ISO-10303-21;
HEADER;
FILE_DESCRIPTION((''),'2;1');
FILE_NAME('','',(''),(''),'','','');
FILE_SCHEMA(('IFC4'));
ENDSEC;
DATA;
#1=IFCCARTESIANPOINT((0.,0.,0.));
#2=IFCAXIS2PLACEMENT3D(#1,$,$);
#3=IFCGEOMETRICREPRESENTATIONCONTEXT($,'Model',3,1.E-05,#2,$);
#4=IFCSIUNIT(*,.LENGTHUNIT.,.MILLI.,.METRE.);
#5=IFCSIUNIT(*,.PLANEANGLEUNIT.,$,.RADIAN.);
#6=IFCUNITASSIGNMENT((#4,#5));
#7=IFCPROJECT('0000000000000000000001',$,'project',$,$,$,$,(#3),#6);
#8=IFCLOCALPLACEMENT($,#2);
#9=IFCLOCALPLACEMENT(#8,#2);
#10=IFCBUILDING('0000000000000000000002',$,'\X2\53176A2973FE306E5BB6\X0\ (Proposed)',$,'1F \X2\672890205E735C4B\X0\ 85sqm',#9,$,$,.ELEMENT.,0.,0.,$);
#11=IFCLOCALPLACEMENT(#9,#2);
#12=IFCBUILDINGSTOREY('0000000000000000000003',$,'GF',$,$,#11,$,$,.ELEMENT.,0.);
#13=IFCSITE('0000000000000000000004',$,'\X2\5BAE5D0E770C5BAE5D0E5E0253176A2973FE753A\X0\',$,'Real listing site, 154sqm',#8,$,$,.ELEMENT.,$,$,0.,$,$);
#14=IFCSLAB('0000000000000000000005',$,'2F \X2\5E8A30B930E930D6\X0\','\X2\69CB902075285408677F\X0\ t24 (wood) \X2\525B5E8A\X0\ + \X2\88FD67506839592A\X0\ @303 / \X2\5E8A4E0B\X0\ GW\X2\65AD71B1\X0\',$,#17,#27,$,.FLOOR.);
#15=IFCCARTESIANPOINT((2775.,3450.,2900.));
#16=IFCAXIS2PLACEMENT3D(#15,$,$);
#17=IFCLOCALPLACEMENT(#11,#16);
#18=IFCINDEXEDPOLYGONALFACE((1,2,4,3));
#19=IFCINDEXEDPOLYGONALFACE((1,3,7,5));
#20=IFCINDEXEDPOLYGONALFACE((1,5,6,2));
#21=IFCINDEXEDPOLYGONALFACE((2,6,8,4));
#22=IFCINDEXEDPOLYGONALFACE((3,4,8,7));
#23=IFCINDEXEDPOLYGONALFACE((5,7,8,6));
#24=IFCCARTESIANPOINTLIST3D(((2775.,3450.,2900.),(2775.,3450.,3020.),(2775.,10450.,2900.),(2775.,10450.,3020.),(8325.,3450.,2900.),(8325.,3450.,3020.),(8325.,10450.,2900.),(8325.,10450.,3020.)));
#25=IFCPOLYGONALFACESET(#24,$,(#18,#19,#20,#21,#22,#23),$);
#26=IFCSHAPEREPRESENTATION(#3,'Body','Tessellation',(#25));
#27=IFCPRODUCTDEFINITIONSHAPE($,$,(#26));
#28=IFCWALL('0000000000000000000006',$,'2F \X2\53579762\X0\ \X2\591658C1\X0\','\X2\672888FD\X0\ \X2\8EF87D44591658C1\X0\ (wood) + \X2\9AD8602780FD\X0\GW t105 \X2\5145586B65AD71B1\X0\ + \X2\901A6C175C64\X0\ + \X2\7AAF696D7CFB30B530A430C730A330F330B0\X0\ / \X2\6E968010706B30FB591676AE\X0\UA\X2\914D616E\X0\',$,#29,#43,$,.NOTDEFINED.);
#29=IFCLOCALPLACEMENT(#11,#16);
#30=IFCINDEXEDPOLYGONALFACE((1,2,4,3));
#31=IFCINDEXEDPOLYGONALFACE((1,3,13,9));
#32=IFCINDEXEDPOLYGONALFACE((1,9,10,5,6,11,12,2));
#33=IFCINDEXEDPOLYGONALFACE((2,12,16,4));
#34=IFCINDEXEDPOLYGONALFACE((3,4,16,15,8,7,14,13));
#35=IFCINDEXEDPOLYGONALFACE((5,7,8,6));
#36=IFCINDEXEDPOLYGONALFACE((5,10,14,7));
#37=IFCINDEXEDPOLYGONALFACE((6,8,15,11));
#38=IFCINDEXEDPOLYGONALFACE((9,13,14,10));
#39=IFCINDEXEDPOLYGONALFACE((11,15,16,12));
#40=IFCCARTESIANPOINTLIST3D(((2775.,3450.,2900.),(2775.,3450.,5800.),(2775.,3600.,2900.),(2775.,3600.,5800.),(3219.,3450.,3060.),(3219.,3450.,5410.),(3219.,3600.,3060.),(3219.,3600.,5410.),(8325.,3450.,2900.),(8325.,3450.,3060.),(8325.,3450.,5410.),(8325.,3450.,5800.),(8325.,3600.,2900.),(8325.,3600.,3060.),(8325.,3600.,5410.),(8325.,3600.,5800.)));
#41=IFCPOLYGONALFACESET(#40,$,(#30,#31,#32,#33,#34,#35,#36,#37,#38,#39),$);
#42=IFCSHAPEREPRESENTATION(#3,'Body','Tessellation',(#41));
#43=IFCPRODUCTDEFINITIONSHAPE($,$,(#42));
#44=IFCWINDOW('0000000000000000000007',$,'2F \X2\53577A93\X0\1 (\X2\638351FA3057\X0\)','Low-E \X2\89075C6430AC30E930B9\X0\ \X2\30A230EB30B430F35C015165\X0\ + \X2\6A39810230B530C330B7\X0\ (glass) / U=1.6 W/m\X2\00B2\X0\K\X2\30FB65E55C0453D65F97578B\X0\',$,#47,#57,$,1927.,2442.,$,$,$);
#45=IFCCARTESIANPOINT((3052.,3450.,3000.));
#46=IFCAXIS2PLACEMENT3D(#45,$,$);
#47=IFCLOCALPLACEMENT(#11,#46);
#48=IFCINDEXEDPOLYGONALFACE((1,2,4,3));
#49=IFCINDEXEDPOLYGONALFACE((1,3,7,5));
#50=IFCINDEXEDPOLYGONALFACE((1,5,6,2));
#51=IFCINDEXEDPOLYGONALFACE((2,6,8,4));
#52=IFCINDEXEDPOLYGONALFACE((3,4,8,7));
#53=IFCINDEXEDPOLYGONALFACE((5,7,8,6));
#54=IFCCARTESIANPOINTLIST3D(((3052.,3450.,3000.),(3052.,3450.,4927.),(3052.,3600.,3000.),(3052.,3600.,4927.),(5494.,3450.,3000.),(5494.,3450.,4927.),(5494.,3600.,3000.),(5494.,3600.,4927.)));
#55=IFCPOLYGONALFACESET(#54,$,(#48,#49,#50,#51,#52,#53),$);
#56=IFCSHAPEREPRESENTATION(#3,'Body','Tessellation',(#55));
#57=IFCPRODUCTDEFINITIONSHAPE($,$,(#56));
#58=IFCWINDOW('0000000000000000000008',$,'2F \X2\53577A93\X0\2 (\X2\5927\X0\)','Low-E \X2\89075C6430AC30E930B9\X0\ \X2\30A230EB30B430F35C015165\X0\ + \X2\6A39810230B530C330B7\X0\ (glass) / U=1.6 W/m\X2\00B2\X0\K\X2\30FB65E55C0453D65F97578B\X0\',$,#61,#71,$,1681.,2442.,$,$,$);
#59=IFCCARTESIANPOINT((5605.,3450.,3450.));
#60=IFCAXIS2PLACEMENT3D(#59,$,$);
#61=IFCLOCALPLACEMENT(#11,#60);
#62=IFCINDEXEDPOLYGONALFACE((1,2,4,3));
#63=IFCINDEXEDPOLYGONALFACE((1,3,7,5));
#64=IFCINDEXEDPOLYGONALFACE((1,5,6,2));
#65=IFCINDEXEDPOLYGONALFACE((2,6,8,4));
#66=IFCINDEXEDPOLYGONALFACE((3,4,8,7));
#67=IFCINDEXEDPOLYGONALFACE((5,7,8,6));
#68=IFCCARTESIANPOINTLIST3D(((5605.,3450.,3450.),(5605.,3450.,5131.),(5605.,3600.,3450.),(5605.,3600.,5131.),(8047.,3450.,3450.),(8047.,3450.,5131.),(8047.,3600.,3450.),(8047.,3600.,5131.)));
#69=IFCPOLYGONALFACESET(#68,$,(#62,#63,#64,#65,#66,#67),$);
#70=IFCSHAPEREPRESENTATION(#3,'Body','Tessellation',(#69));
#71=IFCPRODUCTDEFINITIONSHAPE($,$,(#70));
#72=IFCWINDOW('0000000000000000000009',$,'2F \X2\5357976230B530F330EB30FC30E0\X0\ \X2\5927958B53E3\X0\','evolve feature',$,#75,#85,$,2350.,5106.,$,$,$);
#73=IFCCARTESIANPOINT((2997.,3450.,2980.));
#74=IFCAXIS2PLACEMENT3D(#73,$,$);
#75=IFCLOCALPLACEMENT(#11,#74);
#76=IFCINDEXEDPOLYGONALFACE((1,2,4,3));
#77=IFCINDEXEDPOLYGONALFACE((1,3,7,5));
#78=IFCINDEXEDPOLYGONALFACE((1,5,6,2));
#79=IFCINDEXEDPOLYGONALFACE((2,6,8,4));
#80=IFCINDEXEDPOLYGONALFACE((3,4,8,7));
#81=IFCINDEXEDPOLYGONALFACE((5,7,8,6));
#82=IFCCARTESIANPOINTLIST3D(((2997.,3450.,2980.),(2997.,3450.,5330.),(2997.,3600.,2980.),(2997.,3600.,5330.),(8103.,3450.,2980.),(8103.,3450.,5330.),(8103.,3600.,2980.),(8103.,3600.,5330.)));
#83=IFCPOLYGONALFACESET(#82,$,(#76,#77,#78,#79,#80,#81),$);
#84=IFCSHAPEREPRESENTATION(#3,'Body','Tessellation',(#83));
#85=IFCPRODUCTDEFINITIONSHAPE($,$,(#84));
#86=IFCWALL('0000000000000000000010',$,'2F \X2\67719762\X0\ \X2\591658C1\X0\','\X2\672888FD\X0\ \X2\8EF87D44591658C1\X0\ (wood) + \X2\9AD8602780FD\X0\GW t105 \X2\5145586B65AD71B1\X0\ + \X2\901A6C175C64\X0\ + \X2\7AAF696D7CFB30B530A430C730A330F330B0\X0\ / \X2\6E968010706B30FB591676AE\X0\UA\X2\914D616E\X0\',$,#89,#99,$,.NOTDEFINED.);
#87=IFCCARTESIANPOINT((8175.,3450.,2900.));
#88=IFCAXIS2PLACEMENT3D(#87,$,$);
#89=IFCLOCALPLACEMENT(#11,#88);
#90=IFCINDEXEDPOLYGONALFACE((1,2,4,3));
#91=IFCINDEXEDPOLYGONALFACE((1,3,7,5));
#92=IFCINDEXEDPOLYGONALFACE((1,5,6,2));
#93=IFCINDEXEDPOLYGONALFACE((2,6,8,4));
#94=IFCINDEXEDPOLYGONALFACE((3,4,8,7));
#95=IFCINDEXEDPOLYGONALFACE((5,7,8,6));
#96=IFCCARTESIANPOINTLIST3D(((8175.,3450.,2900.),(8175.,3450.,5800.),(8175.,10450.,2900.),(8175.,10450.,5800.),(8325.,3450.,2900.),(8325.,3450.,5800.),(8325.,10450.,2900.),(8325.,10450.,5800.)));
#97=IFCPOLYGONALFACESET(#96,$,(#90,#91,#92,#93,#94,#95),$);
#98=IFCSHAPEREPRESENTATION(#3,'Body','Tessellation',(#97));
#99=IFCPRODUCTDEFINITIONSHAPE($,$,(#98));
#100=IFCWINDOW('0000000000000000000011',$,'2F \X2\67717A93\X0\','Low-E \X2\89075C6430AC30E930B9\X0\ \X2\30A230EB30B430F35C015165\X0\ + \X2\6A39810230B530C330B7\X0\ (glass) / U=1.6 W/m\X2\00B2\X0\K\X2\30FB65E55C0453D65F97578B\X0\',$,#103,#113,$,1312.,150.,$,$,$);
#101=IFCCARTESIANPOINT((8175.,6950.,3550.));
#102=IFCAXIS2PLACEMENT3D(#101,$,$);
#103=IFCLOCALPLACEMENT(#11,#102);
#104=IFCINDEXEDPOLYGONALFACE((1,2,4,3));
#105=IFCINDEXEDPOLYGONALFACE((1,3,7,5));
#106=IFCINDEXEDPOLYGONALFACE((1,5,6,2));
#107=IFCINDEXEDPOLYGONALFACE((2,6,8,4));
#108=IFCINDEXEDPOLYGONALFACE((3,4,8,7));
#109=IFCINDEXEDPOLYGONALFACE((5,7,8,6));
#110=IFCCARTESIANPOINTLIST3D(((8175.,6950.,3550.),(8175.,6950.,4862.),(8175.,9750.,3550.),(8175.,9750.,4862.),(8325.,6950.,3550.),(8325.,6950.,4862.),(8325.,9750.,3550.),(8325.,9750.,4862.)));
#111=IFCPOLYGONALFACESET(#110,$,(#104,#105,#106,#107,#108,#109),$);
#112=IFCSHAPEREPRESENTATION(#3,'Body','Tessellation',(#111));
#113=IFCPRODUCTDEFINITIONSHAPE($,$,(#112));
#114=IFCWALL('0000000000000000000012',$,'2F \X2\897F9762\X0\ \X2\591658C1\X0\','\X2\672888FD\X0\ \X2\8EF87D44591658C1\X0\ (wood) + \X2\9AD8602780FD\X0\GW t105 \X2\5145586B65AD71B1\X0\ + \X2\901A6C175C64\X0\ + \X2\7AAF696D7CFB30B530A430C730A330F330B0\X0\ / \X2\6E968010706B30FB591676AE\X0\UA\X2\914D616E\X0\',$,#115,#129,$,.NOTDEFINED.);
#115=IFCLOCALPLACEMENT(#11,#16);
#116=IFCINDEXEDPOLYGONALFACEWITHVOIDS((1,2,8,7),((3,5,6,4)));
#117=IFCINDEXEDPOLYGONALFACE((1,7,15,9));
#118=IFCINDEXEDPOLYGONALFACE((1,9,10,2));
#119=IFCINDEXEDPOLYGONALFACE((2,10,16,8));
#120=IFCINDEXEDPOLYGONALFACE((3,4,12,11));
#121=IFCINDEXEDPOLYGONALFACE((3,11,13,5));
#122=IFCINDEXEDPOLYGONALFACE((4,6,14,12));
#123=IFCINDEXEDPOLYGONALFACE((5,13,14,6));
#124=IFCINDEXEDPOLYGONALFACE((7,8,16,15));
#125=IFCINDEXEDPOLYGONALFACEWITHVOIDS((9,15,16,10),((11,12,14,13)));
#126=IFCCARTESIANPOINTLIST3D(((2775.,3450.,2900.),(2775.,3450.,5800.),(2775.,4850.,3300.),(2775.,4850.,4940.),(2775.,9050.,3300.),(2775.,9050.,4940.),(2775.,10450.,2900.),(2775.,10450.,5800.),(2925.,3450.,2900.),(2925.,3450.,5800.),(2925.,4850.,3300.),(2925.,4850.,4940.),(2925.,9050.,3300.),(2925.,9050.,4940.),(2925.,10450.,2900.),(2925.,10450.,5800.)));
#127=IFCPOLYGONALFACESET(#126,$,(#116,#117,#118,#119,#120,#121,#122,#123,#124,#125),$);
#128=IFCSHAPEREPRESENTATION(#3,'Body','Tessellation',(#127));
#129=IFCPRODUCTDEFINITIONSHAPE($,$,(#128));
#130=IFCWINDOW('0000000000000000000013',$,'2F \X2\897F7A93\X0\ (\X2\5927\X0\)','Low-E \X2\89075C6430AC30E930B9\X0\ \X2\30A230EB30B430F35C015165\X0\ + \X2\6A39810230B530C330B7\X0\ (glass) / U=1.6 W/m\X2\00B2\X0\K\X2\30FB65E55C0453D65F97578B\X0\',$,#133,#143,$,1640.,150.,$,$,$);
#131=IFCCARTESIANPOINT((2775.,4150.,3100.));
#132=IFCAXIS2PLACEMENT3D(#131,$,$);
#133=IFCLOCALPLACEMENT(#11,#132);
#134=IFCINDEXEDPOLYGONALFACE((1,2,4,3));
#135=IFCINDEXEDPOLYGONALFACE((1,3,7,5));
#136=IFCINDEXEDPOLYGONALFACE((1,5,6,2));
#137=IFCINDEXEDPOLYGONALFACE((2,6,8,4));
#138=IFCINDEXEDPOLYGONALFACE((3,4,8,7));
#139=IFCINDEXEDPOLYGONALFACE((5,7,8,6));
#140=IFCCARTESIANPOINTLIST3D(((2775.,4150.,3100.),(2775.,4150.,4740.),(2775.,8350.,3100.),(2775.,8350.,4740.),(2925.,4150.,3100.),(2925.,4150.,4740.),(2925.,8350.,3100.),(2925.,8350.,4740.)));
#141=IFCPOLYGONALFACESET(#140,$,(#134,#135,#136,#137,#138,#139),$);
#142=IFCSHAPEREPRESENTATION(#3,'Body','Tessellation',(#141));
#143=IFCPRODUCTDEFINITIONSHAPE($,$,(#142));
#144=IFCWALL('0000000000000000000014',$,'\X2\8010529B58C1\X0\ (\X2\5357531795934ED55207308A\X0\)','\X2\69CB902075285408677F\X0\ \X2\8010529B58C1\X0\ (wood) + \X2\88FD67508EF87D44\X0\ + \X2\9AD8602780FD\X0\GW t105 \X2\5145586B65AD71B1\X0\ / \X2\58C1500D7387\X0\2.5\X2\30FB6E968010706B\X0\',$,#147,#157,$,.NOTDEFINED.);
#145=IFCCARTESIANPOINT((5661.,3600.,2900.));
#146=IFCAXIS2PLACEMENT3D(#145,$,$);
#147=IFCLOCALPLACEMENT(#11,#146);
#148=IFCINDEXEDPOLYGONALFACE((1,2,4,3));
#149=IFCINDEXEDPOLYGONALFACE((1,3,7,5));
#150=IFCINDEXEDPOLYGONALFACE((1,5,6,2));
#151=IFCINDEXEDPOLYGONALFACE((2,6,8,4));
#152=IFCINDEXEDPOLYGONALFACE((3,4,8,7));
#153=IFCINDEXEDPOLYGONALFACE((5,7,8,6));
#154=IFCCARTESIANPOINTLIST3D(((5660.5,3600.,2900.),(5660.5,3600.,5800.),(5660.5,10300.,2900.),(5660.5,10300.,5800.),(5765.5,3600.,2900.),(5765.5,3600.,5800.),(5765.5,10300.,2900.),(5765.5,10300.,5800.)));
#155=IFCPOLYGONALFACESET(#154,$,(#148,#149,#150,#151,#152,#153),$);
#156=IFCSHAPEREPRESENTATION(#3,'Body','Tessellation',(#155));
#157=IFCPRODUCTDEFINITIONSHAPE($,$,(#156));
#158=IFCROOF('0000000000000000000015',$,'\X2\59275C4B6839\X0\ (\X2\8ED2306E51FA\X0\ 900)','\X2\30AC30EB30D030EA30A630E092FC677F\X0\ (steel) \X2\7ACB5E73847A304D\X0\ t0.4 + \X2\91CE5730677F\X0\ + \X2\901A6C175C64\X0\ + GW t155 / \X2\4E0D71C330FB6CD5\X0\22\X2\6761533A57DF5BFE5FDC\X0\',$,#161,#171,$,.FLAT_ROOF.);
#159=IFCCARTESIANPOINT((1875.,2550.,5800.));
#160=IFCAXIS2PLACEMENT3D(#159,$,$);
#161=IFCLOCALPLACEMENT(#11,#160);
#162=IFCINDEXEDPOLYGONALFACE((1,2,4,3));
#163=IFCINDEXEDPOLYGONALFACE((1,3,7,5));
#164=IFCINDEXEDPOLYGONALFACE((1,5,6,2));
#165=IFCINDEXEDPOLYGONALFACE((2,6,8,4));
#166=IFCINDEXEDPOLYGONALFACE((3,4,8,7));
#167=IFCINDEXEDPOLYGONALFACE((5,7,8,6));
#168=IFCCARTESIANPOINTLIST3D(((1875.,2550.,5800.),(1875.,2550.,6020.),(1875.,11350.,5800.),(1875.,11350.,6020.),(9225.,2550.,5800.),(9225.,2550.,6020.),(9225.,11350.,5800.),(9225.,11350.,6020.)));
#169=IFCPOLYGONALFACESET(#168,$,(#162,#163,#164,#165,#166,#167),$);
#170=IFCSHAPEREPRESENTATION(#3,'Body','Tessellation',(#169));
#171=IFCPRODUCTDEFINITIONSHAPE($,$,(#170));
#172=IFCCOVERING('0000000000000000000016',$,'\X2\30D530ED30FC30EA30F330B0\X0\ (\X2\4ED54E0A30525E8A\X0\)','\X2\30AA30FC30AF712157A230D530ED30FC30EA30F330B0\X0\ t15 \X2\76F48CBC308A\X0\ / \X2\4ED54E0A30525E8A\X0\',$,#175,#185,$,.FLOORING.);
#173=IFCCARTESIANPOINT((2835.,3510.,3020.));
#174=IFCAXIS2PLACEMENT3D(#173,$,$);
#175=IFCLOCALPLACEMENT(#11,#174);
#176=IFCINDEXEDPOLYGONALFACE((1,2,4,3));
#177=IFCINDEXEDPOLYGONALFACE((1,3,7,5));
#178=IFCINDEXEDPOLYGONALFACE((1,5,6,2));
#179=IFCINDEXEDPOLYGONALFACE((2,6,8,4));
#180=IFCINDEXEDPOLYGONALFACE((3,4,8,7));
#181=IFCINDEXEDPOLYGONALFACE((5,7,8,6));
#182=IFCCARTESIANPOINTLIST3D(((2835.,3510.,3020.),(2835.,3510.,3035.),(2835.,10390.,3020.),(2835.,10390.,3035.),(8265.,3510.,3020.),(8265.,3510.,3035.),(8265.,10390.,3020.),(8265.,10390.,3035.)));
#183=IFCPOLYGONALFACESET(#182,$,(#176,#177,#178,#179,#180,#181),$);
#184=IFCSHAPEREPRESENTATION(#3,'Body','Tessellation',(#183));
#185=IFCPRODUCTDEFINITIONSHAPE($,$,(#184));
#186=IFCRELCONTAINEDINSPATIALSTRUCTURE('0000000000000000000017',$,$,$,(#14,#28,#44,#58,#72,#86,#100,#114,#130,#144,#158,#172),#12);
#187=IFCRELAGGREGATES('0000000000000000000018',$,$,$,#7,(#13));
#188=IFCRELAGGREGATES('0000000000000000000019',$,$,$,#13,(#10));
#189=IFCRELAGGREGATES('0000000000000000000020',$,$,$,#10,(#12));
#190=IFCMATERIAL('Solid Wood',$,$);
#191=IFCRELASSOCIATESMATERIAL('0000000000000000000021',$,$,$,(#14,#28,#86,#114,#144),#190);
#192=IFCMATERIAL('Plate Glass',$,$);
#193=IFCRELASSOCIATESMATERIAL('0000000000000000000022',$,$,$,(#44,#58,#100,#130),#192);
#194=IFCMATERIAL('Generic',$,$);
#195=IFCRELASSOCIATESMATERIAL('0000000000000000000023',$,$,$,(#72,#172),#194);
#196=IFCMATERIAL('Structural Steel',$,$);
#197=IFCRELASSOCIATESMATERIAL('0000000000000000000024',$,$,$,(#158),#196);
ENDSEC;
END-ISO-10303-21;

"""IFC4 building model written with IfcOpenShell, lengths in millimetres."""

from ifc_helpers import new_model, si_unit, frame, frame_2d, origin, place, context, project, spatial, rectangle, extrude, material, element, fill, save


model = new_model("IFC4")

# Units and contexts
model_context = context("Model", 3, precision=1e-05, world=origin())
ifc_project = project(units=[si_unit("LENGTHUNIT", "METRE", prefix="MILLI"), si_unit("PLANEANGLEUNIT", "RADIAN")], contexts=[model_context])

# Site, building, storey
site_placement = place(None, origin())
site = spatial("IfcSite", under=ifc_project, at=site_placement, Name="宮崎県宮崎市北権現町", ObjectType="Real listing site, 154sqm", CompositionType="ELEMENT", RefElevation=0.0)
building_placement = place(site_placement, origin())
building = spatial("IfcBuilding", under=site, at=building_placement, Name="北権現の家 (Proposed)", ObjectType="1F 木造平屋 85sqm", CompositionType="ELEMENT", ElevationOfRefHeight=0.0, ElevationOfTerrain=0.0)
storey_placement = place(building_placement, origin())
storey = spatial("IfcBuildingStorey", under=building, at=storey_placement, Name="GF", CompositionType="ELEMENT", Elevation=0.0)

# Slab
ifc_material_1 = material(Name="Solid Wood")
slab_placement = place(storey_placement, frame((2775.0, 3450.0, 2900.0)))
element("IfcSlab", 1, at=slab_placement, inside=storey, material=ifc_material_1, Name="2F 床スラブ", Description="構造用合板 t24 (wood) 剛床 + 製材根太 @303 / 床下 GW断熱", PredefinedType="FLOOR", context=model_context, shape_type="SweptSolid", body=[
    extrude(rectangle(XDim=5550.0, YDim=7000.0, at=frame_2d((2775.0, 3500.0))), frame((2775.0, 3450.0, 2900.0)), (0.0, 0.0, 1.0), 120.0),
])

# Wall, openings, windows
wall_1_placement = place(storey_placement, frame((2775.0, 3450.0, 2900.0)))
wall_1 = element("IfcWall", 2, at=wall_1_placement, inside=storey, material=ifc_material_1, Name="2F 南面 外壁", Description="木製 軸組外壁 (wood) + 高性能GW t105 充填断熱 + 通気層 + 窯業系サイディング / 準耐火・外皮UA配慮", PredefinedType="NOTDEFINED", context=model_context, shape_type="SweptSolid", body=[
    extrude(rectangle(XDim=5550.0, YDim=150.0, at=frame_2d((2775.0, 75.0))), frame((2775.0, 3450.0, 2900.0)), (0.0, 0.0, 1.0), 2900.0),
])
opening_1_placement = place(storey_placement, frame((3052.0, 3450.0, 3000.0)))
opening_1 = element("IfcOpeningElement", 3, at=opening_1_placement, cuts=wall_1, PredefinedType="NOTDEFINED", context=model_context, shape_type="SweptSolid", body=[
    extrude(rectangle(XDim=2442.0, YDim=150.0, at=frame_2d((1221.0, 75.0))), frame((3052.0, 3450.0, 3000.0)), (0.0, 0.0, 1.0), 1927.0),
])
opening_2_placement = place(storey_placement, frame((5605.0, 3450.0, 3450.0)))
opening_2 = element("IfcOpeningElement", 4, at=opening_2_placement, cuts=wall_1, PredefinedType="NOTDEFINED", context=model_context, shape_type="SweptSolid", body=[
    extrude(rectangle(XDim=2442.0, YDim=150.0, at=frame_2d((1221.0, 75.0))), frame((5605.0, 3450.0, 3450.0)), (0.0, 0.0, 1.0), 1681.0),
])
opening_3_placement = place(storey_placement, frame((2997.0, 3450.0, 2980.0)))
opening_3 = element("IfcOpeningElement", 5, at=opening_3_placement, cuts=wall_1, PredefinedType="NOTDEFINED", context=model_context, shape_type="SweptSolid", body=[
    extrude(rectangle(XDim=5106.0, YDim=150.0, at=frame_2d((2553.0, 75.0))), frame((2997.0, 3450.0, 2980.0)), (0.0, 0.0, 1.0), 2350.0),
])
ifc_material_2 = material(Name="Plate Glass")
window_1_placement = place(storey_placement, frame((3052.0, 3450.0, 3000.0)))
window_1 = element("IfcWindow", 6, at=window_1_placement, inside=storey, material=ifc_material_2, Name="2F 南窓1 (掃出し)", Description="Low-E 複層ガラス アルゴン封入 + 樹脂サッシ (glass) / U=1.6 W/m²K・日射取得型", OverallHeight=1927.0, OverallWidth=2442.0, context=model_context, shape_type="SweptSolid", body=[
    extrude(rectangle(XDim=2442.0, YDim=150.0, at=frame_2d((1221.0, 75.0))), frame((3052.0, 3450.0, 3000.0)), (0.0, 0.0, 1.0), 1927.0),
])
fill(opening_1, window_1)
window_2_placement = place(storey_placement, frame((5605.0, 3450.0, 3450.0)))
window_2 = element("IfcWindow", 7, at=window_2_placement, inside=storey, material=ifc_material_2, Name="2F 南窓2 (大)", Description="Low-E 複層ガラス アルゴン封入 + 樹脂サッシ (glass) / U=1.6 W/m²K・日射取得型", OverallHeight=1681.0, OverallWidth=2442.0, context=model_context, shape_type="SweptSolid", body=[
    extrude(rectangle(XDim=2442.0, YDim=150.0, at=frame_2d((1221.0, 75.0))), frame((5605.0, 3450.0, 3450.0)), (0.0, 0.0, 1.0), 1681.0),
])
fill(opening_2, window_2)
ifc_material_3 = material(Name="Generic")
window_3_placement = place(storey_placement, frame((2997.0, 3450.0, 2980.0)))
window_3 = element("IfcWindow", 8, at=window_3_placement, inside=storey, material=ifc_material_3, Name="2F 南面サンルーム 大開口", Description="evolve feature", OverallHeight=2350.0, OverallWidth=5106.0, context=model_context, shape_type="SweptSolid", body=[
    extrude(rectangle(XDim=5106.0, YDim=150.0, at=frame_2d((2553.0, 75.0))), frame((2997.0, 3450.0, 2980.0)), (0.0, 0.0, 1.0), 2350.0),
])
fill(opening_3, window_3)

# Walls, openings, windows
wall_2_placement = place(storey_placement, frame((8175.0, 3450.0, 2900.0)))
wall_2 = element("IfcWall", 9, at=wall_2_placement, inside=storey, material=ifc_material_1, Name="2F 東面 外壁", Description="木製 軸組外壁 (wood) + 高性能GW t105 充填断熱 + 通気層 + 窯業系サイディング / 準耐火・外皮UA配慮", PredefinedType="NOTDEFINED", context=model_context, shape_type="SweptSolid", body=[
    extrude(rectangle(XDim=150.0, YDim=7000.0, at=frame_2d((75.0, 3500.0))), frame((8175.0, 3450.0, 2900.0)), (0.0, 0.0, 1.0), 2900.0),
])
opening_4_placement = place(storey_placement, frame((8175.0, 6950.0, 3550.0)))
opening_4 = element("IfcOpeningElement", 10, at=opening_4_placement, cuts=wall_2, PredefinedType="NOTDEFINED", context=model_context, shape_type="SweptSolid", body=[
    extrude(rectangle(XDim=150.0, YDim=2800.0, at=frame_2d((75.0, 1400.0))), frame((8175.0, 6950.0, 3550.0)), (0.0, 0.0, 1.0), 1312.0),
])
window_4_placement = place(storey_placement, frame((8175.0, 6950.0, 3550.0)))
window_4 = element("IfcWindow", 11, at=window_4_placement, inside=storey, material=ifc_material_2, Name="2F 東窓", Description="Low-E 複層ガラス アルゴン封入 + 樹脂サッシ (glass) / U=1.6 W/m²K・日射取得型", OverallHeight=1312.0, OverallWidth=150.0, context=model_context, shape_type="SweptSolid", body=[
    extrude(rectangle(XDim=150.0, YDim=2800.0, at=frame_2d((75.0, 1400.0))), frame((8175.0, 6950.0, 3550.0)), (0.0, 0.0, 1.0), 1312.0),
])
fill(opening_4, window_4)
wall_3_placement = place(storey_placement, frame((2775.0, 3450.0, 2900.0)))
wall_3 = element("IfcWall", 12, at=wall_3_placement, inside=storey, material=ifc_material_1, Name="2F 西面 外壁", Description="木製 軸組外壁 (wood) + 高性能GW t105 充填断熱 + 通気層 + 窯業系サイディング / 準耐火・外皮UA配慮", PredefinedType="NOTDEFINED", context=model_context, shape_type="SweptSolid", body=[
    extrude(rectangle(XDim=150.0, YDim=7000.0, at=frame_2d((75.0, 3500.0))), frame((2775.0, 3450.0, 2900.0)), (0.0, 0.0, 1.0), 2900.0),
])
opening_5_placement = place(storey_placement, frame((2775.0, 4150.0, 3100.0)))
opening_5 = element("IfcOpeningElement", 13, at=opening_5_placement, cuts=wall_3, PredefinedType="NOTDEFINED", context=model_context, shape_type="SweptSolid", body=[
    extrude(rectangle(XDim=150.0, YDim=4200.0, at=frame_2d((75.0, 2100.0))), frame((2775.0, 4150.0, 3100.0)), (0.0, 0.0, 1.0), 1640.0),
])
window_5_placement = place(storey_placement, frame((2775.0, 4150.0, 3100.0)))
window_5 = element("IfcWindow", 14, at=window_5_placement, inside=storey, material=ifc_material_2, Name="2F 西窓 (大)", Description="Low-E 複層ガラス アルゴン封入 + 樹脂サッシ (glass) / U=1.6 W/m²K・日射取得型", OverallHeight=1640.0, OverallWidth=150.0, context=model_context, shape_type="SweptSolid", body=[
    extrude(rectangle(XDim=150.0, YDim=4200.0, at=frame_2d((75.0, 2100.0))), frame((2775.0, 4150.0, 3100.0)), (0.0, 0.0, 1.0), 1640.0),
])
fill(opening_5, window_5)

# Wall
wall_4_placement = place(storey_placement, frame((5661.0, 3600.0, 2900.0)))
element("IfcWall", 15, at=wall_4_placement, inside=storey, material=ifc_material_1, Name="耐力壁 (南北間仕切り)", Description="構造用合板 耐力壁 (wood) + 製材軸組 + 高性能GW t105 充填断熱 / 壁倍率2.5・準耐火", PredefinedType="NOTDEFINED", context=model_context, shape_type="SweptSolid", body=[
    extrude(rectangle(XDim=105.0, YDim=6700.0, at=frame_2d((52.0, 3350.0))), frame((5661.0, 3600.0, 2900.0)), (0.0, 0.0, 1.0), 2900.0),
])

# Roof
ifc_material_4 = material(Name="Structural Steel")
roof_placement = place(storey_placement, frame((1875.0, 2550.0, 5800.0)))
element("IfcRoof", 16, at=roof_placement, inside=storey, material=ifc_material_4, Name="大屋根 (軒の出 900)", Description="ガルバリウム鋼板 (steel) 立平葺き t0.4 + 野地板 + 通気層 + GW t155 / 不燃・法22条区域対応", PredefinedType="FLAT_ROOF", context=model_context, shape_type="SweptSolid", body=[
    extrude(rectangle(XDim=7350.0, YDim=8800.0, at=frame_2d((3675.0, 4400.0))), frame((1875.0, 2550.0, 5800.0)), (0.0, 0.0, 1.0), 220.0),
])

# Covering
covering_placement = place(storey_placement, frame((2835.0, 3510.0, 3020.0)))
element("IfcCovering", 17, at=covering_placement, inside=storey, material=ifc_material_3, Name="フローリング (仕上げ床)", Description="オーク無垢フローリング t15 直貼り / 仕上げ床", PredefinedType="FLOORING", context=model_context, shape_type="SweptSolid", body=[
    extrude(rectangle(XDim=5430.0, YDim=6880.0, at=frame_2d((2715.0, 3440.0))), frame((2835.0, 3510.0, 3020.0)), (0.0, 0.0, 1.0), 15.0),
])

save(model, "model.ifc")
